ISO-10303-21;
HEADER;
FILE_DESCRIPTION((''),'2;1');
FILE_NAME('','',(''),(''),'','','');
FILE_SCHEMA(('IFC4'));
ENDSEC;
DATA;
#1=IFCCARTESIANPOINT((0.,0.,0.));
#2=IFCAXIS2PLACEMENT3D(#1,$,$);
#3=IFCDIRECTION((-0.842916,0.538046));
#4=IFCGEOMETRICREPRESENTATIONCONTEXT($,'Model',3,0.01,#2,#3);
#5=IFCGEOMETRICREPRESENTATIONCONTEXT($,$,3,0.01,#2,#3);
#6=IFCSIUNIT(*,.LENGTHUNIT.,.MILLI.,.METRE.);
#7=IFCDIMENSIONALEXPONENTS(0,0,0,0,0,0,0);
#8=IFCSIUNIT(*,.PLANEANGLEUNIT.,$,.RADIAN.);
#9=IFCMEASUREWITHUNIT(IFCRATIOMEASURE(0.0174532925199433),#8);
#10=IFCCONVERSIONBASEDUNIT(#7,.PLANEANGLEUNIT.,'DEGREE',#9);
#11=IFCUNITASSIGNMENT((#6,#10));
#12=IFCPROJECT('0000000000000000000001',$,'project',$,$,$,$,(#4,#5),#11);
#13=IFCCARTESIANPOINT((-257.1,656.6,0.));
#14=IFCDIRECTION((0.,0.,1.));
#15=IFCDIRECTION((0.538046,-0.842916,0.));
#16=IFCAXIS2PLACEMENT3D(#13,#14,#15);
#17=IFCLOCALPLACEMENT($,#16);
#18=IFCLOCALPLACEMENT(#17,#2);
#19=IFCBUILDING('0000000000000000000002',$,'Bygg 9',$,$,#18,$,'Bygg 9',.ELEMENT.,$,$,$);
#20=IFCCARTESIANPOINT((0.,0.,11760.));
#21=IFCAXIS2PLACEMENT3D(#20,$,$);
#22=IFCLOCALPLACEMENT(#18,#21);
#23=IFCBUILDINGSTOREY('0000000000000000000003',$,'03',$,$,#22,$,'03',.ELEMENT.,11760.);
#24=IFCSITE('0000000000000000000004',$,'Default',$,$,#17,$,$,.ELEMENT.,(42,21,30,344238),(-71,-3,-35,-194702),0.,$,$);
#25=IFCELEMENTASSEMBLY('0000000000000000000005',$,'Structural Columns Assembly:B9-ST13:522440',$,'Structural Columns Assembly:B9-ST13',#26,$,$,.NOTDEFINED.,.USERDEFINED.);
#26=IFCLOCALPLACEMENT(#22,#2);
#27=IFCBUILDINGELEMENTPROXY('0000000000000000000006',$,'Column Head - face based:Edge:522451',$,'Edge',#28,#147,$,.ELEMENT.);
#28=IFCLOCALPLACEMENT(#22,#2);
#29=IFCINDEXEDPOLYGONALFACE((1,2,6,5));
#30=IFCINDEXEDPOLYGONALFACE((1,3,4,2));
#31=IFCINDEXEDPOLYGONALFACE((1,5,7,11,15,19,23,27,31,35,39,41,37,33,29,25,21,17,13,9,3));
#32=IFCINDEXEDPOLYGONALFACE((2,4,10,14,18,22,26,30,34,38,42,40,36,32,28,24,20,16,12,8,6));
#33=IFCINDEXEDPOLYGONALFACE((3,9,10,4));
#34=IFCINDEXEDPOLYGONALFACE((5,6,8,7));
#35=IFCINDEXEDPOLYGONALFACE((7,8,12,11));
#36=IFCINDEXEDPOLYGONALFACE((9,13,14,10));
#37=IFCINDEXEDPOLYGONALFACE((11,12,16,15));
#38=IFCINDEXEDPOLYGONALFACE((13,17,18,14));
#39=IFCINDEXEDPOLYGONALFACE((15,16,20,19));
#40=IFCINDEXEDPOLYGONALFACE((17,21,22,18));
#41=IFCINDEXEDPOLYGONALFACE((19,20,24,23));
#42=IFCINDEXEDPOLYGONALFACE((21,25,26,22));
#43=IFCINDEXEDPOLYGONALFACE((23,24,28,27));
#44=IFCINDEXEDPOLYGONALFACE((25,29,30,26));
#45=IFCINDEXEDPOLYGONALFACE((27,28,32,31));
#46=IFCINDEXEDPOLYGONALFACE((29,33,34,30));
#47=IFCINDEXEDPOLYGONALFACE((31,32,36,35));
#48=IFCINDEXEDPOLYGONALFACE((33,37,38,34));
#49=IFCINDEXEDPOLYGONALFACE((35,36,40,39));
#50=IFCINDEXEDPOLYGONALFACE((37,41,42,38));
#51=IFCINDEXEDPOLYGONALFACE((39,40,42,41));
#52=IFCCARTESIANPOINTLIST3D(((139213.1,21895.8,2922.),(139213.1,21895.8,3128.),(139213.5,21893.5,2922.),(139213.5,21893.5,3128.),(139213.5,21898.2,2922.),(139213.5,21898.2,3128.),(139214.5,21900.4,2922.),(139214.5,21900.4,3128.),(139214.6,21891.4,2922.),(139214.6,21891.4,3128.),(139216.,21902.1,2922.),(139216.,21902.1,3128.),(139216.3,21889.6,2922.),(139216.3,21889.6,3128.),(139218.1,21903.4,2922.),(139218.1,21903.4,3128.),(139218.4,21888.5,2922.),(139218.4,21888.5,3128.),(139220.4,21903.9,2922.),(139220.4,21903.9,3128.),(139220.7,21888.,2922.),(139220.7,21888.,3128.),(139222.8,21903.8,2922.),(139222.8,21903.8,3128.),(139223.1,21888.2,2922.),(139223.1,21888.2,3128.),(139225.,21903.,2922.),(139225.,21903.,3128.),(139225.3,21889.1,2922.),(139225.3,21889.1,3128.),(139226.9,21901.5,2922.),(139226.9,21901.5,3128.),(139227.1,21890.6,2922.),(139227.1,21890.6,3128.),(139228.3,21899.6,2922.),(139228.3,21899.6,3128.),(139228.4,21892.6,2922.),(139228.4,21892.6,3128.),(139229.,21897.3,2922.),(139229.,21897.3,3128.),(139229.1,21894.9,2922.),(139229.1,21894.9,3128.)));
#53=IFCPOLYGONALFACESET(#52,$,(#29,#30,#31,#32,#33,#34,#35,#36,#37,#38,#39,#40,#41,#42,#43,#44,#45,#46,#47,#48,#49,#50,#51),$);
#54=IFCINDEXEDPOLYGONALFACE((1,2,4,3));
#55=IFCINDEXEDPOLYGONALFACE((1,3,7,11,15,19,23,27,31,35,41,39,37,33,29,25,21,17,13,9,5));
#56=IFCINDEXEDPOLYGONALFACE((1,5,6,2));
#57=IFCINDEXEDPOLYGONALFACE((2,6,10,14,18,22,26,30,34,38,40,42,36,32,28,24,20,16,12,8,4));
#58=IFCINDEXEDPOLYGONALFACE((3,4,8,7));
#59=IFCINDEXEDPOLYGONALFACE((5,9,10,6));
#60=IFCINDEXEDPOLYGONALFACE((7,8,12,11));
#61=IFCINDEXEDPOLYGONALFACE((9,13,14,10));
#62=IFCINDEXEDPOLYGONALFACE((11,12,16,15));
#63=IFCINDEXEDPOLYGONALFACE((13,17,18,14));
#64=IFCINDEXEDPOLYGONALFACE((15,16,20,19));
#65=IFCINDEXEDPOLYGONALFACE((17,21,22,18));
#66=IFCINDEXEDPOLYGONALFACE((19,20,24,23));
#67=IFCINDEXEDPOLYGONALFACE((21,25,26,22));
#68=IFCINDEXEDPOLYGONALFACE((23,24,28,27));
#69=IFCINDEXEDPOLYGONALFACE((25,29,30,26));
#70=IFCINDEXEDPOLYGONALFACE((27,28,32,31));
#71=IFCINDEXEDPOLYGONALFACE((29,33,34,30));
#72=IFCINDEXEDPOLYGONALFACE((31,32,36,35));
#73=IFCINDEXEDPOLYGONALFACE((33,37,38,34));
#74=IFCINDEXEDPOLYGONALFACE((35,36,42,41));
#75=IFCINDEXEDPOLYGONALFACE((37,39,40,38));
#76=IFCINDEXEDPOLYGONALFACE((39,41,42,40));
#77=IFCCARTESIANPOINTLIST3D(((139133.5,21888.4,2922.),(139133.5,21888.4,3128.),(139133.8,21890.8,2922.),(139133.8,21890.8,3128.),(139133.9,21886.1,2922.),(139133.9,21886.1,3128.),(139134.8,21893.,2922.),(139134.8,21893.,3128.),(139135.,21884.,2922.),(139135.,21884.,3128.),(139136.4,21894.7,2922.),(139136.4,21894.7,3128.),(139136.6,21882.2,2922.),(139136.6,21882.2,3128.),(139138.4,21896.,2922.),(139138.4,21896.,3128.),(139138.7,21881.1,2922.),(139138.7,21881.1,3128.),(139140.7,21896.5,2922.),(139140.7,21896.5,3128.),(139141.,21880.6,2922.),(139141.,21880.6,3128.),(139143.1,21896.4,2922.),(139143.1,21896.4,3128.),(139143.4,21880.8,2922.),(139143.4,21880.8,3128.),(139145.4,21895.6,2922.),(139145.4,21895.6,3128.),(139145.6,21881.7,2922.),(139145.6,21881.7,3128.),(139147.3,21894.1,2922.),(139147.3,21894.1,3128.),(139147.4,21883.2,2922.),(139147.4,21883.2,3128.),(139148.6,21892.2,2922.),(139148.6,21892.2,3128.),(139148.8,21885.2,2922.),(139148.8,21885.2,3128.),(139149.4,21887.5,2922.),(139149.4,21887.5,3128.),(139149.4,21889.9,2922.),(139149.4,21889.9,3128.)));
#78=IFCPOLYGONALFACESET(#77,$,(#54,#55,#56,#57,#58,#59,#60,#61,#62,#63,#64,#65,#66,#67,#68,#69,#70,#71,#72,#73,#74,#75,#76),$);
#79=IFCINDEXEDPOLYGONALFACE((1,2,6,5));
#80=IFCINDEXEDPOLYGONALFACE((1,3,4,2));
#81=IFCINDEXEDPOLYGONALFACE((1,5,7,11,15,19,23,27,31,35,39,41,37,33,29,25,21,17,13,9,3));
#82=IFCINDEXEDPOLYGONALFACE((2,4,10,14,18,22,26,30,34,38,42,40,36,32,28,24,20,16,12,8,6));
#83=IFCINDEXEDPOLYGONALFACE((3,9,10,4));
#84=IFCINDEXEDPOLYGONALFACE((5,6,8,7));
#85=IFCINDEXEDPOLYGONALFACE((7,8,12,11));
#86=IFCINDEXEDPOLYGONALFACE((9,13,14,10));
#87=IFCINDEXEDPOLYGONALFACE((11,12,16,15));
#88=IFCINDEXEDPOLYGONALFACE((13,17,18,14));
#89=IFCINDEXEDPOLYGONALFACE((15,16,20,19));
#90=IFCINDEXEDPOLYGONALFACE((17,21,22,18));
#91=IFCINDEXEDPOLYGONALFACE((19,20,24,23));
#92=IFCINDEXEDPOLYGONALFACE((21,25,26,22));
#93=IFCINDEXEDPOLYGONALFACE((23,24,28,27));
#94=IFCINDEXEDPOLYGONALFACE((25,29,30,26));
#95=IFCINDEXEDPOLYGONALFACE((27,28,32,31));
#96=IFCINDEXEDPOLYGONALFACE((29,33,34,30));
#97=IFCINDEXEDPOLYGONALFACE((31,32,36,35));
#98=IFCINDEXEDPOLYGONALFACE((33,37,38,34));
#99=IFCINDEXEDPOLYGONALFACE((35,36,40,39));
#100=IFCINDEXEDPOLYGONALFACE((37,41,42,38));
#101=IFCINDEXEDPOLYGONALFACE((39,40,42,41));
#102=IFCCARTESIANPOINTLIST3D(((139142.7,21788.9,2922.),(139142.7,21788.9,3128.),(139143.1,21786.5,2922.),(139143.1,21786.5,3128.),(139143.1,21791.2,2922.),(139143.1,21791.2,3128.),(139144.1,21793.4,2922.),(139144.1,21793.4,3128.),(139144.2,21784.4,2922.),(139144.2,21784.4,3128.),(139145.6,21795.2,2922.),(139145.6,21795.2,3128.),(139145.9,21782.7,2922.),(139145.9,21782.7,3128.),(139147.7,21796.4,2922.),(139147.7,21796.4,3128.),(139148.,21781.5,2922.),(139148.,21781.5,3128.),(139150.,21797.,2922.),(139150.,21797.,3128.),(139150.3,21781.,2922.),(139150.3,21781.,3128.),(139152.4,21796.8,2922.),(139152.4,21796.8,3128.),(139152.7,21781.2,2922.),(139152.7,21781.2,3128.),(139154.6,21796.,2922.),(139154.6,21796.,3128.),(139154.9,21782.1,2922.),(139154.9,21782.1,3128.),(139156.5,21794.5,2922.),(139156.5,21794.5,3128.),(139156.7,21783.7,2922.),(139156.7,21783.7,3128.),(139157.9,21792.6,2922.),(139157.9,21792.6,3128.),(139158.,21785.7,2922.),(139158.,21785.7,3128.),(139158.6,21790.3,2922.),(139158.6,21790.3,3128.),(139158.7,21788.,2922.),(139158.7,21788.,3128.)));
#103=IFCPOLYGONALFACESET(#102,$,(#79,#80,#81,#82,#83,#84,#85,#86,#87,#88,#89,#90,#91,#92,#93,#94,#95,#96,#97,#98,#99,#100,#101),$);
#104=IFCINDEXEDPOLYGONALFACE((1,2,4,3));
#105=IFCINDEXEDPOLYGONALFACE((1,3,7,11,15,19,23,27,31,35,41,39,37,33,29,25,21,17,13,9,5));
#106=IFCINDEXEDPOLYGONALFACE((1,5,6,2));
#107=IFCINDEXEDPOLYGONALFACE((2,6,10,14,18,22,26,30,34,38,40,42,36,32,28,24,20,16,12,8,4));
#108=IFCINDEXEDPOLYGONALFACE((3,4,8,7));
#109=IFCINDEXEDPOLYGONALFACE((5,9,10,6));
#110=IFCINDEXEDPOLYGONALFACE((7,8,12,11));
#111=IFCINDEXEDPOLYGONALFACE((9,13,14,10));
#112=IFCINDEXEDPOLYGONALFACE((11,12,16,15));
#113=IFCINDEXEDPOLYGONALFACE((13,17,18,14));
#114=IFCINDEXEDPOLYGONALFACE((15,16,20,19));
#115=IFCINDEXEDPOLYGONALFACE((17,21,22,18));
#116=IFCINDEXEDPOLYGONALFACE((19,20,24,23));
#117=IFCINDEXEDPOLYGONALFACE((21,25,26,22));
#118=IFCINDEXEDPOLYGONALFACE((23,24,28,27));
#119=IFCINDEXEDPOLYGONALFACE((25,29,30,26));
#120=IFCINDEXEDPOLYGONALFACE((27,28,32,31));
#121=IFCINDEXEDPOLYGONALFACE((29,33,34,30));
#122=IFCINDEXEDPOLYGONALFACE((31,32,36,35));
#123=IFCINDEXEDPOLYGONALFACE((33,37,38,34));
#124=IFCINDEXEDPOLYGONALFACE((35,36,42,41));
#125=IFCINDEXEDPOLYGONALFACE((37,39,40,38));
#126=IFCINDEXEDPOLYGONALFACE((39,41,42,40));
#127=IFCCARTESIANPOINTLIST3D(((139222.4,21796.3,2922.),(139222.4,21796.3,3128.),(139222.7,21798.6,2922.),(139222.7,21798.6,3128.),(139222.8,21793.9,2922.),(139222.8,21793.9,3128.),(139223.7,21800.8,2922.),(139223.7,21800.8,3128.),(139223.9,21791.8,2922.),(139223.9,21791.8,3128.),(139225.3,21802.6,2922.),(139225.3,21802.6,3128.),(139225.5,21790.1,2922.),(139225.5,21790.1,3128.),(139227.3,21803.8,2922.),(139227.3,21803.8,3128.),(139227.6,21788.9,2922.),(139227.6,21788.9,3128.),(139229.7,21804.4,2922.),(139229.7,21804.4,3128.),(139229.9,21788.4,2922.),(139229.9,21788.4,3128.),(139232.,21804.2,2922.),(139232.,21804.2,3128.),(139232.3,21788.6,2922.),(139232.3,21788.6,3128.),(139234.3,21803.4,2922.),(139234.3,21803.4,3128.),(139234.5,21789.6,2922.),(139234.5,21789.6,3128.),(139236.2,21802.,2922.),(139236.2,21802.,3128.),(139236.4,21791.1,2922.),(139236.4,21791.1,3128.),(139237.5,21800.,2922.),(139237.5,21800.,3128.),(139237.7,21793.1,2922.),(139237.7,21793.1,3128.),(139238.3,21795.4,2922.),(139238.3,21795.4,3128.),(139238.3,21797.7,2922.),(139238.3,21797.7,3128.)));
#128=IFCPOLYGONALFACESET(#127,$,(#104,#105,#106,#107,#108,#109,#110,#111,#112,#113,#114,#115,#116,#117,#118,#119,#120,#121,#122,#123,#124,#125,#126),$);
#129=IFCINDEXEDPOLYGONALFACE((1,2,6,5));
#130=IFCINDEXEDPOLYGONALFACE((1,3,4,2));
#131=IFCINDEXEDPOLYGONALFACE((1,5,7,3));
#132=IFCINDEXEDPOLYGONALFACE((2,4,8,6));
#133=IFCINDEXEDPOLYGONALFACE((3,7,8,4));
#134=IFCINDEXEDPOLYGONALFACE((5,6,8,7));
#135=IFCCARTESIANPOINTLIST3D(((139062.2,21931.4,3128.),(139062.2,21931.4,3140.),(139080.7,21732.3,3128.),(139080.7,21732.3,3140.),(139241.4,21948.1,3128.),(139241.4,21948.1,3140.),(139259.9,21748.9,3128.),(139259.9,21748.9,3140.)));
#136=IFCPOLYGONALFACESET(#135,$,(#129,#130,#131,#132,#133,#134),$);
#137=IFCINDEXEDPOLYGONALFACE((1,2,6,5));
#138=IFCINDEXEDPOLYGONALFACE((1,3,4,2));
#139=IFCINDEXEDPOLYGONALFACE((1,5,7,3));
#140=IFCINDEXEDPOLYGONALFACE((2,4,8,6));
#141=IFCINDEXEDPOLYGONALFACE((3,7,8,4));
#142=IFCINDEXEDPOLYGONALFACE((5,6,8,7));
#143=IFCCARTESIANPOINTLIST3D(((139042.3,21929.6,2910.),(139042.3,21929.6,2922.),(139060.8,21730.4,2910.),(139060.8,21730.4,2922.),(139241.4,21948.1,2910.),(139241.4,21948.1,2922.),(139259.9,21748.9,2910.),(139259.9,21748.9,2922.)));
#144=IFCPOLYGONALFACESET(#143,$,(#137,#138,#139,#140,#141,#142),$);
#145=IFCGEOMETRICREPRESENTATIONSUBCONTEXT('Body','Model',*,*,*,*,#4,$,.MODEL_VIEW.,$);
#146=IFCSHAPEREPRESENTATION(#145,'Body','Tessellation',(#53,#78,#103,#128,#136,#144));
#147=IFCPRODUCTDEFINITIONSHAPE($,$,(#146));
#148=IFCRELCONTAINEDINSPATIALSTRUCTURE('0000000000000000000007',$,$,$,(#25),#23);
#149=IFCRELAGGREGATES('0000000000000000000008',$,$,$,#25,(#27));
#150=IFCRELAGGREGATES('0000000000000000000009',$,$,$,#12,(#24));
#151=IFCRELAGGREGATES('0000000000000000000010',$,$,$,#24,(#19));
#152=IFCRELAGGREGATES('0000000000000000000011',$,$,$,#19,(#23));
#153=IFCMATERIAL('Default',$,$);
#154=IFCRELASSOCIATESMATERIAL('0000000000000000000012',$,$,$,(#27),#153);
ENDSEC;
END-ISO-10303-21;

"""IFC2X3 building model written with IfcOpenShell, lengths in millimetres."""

from ifc_helpers import new_model, entity, si_unit, converted_unit, direction, frame, frame_2d, origin, origin_2d_with_axis, place, context, subcontext, project, spatial, rectangle, circle, extrude, source, transform, mapped, material, element, aggregate, save


model = new_model("IFC2X3")

# Units and contexts
model_context = context("Model", 3, precision=0.01, world=origin(), true_north=direction((-0.842916, 0.538046)))
context_of_model = context(None, 3, precision=0.01, world=origin(), true_north=direction((-0.842916, 0.538046)))
body_context = subcontext(model_context, "Body", "Model", "MODEL_VIEW")
ifc_project = project(units=[si_unit("LENGTHUNIT", "METRE", prefix="MILLI"), converted_unit("PLANEANGLEUNIT", "DEGREE", entity("IfcRatioMeasure", 0.0174532925199433), si_unit("PLANEANGLEUNIT", "RADIAN"), dimensions=[0, 0, 0, 0, 0, 0, 0])], contexts=[model_context, context_of_model])

# Site, building, storey
site_placement = place(None, frame((-257.1, 656.6, 0.0), z_axis=(0.0, 0.0, 1.0), x_axis=(0.538046, -0.842916, 0.0)))
site = spatial("IfcSite", under=ifc_project, at=site_placement, Name="Default", CompositionType="ELEMENT", RefLatitude=(42, 21, 30, 344238), RefLongitude=(-71, -3, -35, -194702), RefElevation=0.0)
building_placement = place(site_placement, origin())
building = spatial("IfcBuilding", under=site, at=building_placement, Name="Bygg 9", LongName="Bygg 9", CompositionType="ELEMENT")
storey_placement = place(building_placement, frame((0.0, 0.0, 11760.0)))
storey = spatial("IfcBuildingStorey", under=building, at=storey_placement, Name="03", LongName="03", CompositionType="ELEMENT", Elevation=11760.0)

# Shared definitions
ifc_material_1 = material(Name="Default")

# Element assembly, building element proxy
shared_shape_1 = source(origin(), body_context, "Body", "SweptSolid", [
    extrude(circle(Radius=8.0, at=frame_2d((0.0, 0.0), x_axis=(1.0, 0.0))), frame((50.0, -135.0, 12.0)), (0.0, 0.0, 1.0), 206.0),
    extrude(circle(Radius=8.0, at=frame_2d((0.0, 0.0), x_axis=(1.0, 0.0))), frame((50.0, -55.0, 12.0)), (0.0, 0.0, 1.0), 206.0),
    extrude(circle(Radius=8.0, at=frame_2d((0.0, 0.0), x_axis=(1.0, 0.0))), frame((-50.0, -55.0, 12.0)), (0.0, 0.0, 1.0), 206.0),
    extrude(circle(Radius=8.0, at=frame_2d((0.0, 0.0), x_axis=(1.0, 0.0))), frame((-50.0, -135.0, 12.0)), (0.0, 0.0, 1.0), 206.0),
    extrude(rectangle(XDim=200.0, YDim=180.0, at=origin_2d_with_axis()), frame((0.0, -70.0, 218.0), z_axis=(0.0, 0.0, 1.0), x_axis=(-1.0, 0.0, 0.0)), (0.0, 0.0, 1.0), 12.0),
    extrude(rectangle(XDim=200.0, YDim=200.0, at=origin_2d_with_axis()), frame((0.0, -60.0, 0.0), z_axis=(0.0, 0.0, 1.0), x_axis=(0.0, 1.0, 0.0)), (0.0, 0.0, 1.0), 12.0),
])
assembly_1_placement = place(storey_placement, origin())
assembly_1 = element("IfcElementAssembly", 1, at=assembly_1_placement, inside=storey, Name="Structural Columns Assembly:B9-ST13:522440", ObjectType="Structural Columns Assembly:B9-ST13", AssemblyPlace="NOTDEFINED", PredefinedType="USERDEFINED")
proxy_1_placement = place(assembly_1_placement, frame((139091.4, 21833.7, 2910.0), z_axis=(0.0, 0.0, 1.0), x_axis=(-0.092535, 0.995709, 0.0)))
proxy_1 = element("IfcBuildingElementProxy", 2, at=proxy_1_placement, material=ifc_material_1, Name="Column Head - face based:Edge:522451", ObjectType="Edge", CompositionType="ELEMENT", context=body_context, shape_type="MappedRepresentation", body=[
    mapped(shared_shape_1, transform((0.0, 0.0, 0.0), scale=1.0)),
])
aggregate(assembly_1, [proxy_1])

save(model, "model.ifc")
